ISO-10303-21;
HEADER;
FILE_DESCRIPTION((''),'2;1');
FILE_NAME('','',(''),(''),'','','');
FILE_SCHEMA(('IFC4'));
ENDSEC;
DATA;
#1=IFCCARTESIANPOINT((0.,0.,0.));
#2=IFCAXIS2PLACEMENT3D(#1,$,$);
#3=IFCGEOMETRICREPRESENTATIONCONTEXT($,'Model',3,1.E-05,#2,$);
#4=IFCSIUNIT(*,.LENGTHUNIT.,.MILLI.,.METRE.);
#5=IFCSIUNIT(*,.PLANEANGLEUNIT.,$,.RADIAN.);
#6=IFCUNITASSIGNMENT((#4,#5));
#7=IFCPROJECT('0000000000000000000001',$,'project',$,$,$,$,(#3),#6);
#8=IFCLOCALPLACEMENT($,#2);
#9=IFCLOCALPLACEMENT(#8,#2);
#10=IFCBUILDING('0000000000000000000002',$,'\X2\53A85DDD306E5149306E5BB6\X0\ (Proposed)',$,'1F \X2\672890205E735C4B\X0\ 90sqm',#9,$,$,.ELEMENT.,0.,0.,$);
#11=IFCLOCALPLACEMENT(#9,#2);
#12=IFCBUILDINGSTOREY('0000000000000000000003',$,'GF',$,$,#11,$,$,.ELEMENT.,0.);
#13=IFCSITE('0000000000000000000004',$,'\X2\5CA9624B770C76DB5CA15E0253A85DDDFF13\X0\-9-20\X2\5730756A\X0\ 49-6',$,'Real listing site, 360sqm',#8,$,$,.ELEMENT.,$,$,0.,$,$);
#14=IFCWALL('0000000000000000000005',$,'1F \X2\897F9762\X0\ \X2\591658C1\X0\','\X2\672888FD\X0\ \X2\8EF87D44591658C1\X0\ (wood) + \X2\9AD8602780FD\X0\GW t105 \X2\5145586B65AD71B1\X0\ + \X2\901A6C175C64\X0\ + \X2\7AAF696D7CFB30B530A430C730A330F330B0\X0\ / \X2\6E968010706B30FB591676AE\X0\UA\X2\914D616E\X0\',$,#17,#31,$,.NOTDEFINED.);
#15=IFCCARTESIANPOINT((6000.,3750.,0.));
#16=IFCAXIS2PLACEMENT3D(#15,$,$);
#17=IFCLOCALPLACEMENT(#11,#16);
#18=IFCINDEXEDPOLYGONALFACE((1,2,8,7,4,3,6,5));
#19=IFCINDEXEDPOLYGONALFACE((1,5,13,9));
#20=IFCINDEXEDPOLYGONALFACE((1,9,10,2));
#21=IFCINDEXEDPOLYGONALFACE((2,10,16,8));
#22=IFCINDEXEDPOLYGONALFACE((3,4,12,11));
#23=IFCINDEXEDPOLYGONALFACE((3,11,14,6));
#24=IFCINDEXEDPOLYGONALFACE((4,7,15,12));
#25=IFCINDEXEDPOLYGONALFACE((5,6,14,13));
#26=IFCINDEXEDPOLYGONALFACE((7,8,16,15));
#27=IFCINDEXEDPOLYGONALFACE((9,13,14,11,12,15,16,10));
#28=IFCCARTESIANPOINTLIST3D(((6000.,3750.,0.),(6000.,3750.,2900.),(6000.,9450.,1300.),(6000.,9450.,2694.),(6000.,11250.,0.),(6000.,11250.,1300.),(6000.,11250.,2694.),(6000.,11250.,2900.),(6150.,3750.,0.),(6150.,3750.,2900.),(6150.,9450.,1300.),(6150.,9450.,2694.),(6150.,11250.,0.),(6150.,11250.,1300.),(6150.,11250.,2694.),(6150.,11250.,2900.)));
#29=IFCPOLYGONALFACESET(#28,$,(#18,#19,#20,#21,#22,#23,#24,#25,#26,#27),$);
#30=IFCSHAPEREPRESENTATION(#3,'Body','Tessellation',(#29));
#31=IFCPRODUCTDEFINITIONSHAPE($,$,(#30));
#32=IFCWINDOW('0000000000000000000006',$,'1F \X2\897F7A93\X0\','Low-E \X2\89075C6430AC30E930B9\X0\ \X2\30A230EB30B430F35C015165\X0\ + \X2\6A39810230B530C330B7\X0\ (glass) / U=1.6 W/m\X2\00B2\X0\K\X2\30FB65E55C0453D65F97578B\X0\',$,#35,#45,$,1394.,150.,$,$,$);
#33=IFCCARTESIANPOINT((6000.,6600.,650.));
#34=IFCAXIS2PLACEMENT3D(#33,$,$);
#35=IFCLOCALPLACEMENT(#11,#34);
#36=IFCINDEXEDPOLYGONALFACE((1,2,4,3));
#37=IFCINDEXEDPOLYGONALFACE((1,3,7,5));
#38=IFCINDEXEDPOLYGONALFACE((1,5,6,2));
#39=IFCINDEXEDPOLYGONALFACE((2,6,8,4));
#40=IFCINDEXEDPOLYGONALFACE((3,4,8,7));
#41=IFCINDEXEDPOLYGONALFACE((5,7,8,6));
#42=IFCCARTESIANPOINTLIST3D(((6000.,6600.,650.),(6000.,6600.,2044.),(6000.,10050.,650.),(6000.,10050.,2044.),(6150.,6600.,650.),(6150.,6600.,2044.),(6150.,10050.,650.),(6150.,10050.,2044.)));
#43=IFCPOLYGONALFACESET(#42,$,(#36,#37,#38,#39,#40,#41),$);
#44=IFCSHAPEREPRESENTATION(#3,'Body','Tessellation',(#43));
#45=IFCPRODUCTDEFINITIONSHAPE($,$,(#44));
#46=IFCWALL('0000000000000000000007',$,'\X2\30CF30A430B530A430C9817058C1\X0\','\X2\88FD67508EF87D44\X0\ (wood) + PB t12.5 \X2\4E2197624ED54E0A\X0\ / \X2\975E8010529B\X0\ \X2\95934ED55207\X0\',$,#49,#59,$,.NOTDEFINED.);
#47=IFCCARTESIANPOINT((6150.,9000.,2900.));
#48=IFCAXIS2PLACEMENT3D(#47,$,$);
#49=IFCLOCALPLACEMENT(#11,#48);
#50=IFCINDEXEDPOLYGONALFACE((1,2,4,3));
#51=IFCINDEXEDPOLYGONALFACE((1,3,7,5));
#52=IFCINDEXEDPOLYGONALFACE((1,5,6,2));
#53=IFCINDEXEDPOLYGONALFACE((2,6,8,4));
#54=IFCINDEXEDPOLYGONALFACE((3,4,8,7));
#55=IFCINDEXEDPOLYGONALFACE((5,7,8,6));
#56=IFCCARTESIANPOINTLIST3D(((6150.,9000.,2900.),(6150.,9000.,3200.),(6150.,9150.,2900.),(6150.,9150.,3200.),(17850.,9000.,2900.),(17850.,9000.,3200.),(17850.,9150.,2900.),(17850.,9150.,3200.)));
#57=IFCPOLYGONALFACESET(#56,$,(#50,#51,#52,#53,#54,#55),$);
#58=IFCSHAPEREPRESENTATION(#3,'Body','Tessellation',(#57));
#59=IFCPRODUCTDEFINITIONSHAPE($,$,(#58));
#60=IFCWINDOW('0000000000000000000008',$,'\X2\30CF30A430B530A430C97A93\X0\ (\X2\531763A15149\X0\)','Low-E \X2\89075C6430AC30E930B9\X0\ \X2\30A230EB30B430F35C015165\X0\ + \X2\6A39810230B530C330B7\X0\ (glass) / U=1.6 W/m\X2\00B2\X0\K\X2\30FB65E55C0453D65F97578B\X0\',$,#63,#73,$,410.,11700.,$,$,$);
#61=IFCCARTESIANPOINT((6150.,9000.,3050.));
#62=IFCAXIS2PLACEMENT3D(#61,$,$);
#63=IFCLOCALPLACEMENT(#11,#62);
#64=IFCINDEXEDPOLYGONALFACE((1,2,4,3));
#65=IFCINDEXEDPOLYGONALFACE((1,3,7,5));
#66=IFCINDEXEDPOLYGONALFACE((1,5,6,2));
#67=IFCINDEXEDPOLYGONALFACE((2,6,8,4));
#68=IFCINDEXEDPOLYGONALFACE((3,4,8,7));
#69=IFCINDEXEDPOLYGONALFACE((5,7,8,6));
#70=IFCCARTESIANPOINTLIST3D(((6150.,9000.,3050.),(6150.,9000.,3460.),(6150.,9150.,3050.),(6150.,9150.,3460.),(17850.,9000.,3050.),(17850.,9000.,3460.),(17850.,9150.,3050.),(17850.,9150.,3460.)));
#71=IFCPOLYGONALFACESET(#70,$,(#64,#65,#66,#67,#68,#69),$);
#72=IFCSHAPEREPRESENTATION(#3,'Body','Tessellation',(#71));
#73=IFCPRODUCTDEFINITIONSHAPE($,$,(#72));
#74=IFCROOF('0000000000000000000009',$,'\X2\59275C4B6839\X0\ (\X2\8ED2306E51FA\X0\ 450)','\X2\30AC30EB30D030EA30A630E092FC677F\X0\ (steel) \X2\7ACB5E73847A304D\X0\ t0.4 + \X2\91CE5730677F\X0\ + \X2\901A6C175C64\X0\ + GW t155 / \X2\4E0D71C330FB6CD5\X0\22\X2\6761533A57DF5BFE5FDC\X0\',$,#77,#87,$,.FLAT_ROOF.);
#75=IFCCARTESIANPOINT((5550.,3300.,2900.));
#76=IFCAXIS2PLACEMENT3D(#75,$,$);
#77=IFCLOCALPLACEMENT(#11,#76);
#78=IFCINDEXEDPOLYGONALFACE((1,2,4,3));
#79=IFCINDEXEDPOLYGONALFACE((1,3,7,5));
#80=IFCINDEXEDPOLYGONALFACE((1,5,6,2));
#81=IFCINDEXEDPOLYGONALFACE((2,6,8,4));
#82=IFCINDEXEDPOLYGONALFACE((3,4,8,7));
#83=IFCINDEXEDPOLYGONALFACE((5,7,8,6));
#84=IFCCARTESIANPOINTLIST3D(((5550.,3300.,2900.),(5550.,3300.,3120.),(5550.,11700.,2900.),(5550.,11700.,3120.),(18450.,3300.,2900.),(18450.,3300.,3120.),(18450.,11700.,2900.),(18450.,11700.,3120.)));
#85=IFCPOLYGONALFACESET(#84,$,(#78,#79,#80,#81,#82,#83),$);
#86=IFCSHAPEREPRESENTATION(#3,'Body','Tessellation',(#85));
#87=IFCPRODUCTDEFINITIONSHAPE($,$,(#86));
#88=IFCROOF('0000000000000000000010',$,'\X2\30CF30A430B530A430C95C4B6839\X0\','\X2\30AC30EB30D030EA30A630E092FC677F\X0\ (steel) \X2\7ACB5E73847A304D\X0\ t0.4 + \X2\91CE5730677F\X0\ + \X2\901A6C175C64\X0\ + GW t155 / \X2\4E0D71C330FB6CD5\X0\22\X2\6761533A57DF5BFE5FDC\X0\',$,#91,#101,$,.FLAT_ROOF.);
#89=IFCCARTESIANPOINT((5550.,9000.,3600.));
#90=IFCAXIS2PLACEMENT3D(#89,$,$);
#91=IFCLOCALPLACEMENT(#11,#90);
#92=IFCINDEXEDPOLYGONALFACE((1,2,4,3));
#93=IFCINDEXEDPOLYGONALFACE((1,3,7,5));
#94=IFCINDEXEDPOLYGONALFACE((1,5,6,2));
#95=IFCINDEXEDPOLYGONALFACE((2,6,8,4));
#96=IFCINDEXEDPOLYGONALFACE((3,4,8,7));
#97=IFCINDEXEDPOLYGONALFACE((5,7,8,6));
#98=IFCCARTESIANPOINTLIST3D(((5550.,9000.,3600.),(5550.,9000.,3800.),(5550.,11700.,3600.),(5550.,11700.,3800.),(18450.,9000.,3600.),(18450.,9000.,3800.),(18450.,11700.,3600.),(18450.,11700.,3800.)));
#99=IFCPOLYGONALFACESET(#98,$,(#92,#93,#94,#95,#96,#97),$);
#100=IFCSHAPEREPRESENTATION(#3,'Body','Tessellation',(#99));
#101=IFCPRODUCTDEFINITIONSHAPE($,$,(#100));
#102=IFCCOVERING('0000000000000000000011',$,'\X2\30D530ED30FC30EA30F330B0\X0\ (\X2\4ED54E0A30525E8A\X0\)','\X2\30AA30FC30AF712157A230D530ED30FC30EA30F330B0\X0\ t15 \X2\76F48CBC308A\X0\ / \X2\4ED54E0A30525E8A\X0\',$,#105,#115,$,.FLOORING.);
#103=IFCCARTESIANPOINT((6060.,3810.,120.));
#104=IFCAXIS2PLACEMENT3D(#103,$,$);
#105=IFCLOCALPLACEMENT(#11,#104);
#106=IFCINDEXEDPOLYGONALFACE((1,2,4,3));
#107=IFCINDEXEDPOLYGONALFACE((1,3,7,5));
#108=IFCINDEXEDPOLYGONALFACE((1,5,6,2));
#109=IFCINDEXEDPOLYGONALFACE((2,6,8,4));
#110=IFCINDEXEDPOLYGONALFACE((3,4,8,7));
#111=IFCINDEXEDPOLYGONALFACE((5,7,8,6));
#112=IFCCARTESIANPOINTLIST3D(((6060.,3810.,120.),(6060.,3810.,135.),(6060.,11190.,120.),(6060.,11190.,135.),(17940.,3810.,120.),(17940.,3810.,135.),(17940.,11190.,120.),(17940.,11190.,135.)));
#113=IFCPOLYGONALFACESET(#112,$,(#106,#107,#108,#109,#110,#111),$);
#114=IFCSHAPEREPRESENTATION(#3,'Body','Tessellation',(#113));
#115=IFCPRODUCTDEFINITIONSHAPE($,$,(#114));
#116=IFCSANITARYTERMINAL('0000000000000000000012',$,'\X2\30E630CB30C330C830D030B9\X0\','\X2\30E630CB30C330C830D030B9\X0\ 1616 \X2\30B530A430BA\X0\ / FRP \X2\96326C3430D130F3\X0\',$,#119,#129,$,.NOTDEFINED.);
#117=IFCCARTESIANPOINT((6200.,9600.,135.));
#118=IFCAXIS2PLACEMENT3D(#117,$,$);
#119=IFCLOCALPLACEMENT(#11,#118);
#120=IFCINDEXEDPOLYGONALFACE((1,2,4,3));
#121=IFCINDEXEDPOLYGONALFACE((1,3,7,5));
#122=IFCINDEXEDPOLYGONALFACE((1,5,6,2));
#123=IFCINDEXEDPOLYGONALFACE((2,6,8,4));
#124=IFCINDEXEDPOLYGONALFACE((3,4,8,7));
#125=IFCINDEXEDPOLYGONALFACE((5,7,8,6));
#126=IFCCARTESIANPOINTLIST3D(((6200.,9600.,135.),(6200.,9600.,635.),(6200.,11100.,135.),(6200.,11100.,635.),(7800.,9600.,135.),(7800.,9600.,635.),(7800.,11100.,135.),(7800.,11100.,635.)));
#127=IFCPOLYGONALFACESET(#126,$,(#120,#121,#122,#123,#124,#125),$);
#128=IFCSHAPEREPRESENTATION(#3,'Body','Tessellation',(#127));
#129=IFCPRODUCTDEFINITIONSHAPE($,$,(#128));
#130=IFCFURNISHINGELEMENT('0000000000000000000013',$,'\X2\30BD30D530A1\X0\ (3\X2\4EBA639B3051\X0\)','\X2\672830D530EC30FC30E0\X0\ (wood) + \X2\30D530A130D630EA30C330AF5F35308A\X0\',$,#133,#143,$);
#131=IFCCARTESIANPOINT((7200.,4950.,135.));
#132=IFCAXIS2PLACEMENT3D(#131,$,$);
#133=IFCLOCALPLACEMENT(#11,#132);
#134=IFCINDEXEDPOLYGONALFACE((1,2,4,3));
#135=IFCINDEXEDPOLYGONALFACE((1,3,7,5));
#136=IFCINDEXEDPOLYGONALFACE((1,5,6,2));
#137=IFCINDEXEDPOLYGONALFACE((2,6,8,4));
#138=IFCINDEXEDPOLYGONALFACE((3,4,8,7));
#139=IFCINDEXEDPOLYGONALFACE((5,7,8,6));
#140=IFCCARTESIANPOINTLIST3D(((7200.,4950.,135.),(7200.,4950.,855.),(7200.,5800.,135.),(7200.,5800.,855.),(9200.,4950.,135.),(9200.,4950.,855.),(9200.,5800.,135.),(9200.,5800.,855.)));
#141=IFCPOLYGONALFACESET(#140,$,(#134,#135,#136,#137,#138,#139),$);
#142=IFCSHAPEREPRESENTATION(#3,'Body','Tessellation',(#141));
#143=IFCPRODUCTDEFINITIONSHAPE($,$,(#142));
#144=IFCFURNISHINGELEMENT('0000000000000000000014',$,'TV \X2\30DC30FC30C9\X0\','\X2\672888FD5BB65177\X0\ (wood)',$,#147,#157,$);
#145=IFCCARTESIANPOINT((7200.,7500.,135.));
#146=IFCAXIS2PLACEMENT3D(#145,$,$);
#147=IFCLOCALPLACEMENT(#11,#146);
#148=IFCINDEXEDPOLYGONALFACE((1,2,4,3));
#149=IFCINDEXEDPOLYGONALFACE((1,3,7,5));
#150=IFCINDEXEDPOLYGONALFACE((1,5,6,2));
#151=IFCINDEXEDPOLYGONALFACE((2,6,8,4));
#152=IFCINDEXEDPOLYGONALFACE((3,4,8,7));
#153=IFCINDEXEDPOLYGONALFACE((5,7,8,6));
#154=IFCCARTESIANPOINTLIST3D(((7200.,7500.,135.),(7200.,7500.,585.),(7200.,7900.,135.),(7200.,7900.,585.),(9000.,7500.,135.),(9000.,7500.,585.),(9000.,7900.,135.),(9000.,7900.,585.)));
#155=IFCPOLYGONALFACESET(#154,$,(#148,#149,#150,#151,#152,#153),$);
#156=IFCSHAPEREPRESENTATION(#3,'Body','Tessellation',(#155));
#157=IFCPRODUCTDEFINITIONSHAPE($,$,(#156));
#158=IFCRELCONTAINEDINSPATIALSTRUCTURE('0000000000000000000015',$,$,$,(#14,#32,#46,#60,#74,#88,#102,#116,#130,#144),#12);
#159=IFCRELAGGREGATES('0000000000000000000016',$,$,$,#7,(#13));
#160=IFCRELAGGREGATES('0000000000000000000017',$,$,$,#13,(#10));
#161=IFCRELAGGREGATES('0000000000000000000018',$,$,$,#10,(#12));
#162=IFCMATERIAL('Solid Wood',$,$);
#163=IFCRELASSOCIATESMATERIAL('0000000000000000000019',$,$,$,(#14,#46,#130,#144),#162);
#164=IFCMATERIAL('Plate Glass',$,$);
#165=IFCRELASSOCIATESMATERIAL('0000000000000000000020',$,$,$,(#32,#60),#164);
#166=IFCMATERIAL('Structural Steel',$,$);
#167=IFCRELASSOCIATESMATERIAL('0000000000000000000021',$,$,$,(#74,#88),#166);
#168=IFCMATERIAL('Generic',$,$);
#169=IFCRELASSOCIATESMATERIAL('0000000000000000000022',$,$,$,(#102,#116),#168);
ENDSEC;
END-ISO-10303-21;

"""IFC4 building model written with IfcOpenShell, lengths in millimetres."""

from ifc_helpers import new_model, si_unit, frame, frame_2d, origin, place, context, project, spatial, rectangle, extrude, material, element, fill, save


model = new_model("IFC4")

# Units and contexts
model_context = context("Model", 3, precision=1e-05, world=origin())
ifc_project = project(units=[si_unit("LENGTHUNIT", "METRE", prefix="MILLI"), si_unit("PLANEANGLEUNIT", "RADIAN")], contexts=[model_context])

# Site, building, storey
site_placement = place(None, origin())
site = spatial("IfcSite", under=ifc_project, at=site_placement, Name="岩手県盛岡市厨川３-9-20地番 49-6", ObjectType="Real listing site, 360sqm", CompositionType="ELEMENT", RefElevation=0.0)
building_placement = place(site_placement, origin())
building = spatial("IfcBuilding", under=site, at=building_placement, Name="厨川の光の家 (Proposed)", ObjectType="1F 木造平屋 90sqm", CompositionType="ELEMENT", ElevationOfRefHeight=0.0, ElevationOfTerrain=0.0)
storey_placement = place(building_placement, origin())
storey = spatial("IfcBuildingStorey", under=building, at=storey_placement, Name="GF", CompositionType="ELEMENT", Elevation=0.0)

# Shared definitions
ifc_material_1 = material(Name="Solid Wood")

# Shared definitions
ifc_material_2 = material(Name="Plate Glass")

# Wall, opening, window
wall_1_placement = place(storey_placement, frame((6000.0, 3750.0, 0.0)))
wall_1 = element("IfcWall", 1, at=wall_1_placement, inside=storey, material=ifc_material_1, Name="1F 西面 外壁", Description="木製 軸組外壁 (wood) + 高性能GW t105 充填断熱 + 通気層 + 窯業系サイディング / 準耐火・外皮UA配慮", PredefinedType="NOTDEFINED", context=model_context, shape_type="SweptSolid", body=[
    extrude(rectangle(XDim=150.0, YDim=7500.0, at=frame_2d((75.0, 3750.0))), frame((6000.0, 3750.0, 0.0)), (0.0, 0.0, 1.0), 2900.0),
])
opening_1_placement = place(storey_placement, frame((6000.0, 6600.0, 650.0)))
opening_1 = element("IfcOpeningElement", 2, at=opening_1_placement, cuts=wall_1, PredefinedType="NOTDEFINED", context=model_context, shape_type="SweptSolid", body=[
    extrude(rectangle(XDim=150.0, YDim=3450.0, at=frame_2d((75.0, 1725.0))), frame((6000.0, 6600.0, 650.0)), (0.0, 0.0, 1.0), 1394.0),
])
window_1_placement = place(storey_placement, frame((6000.0, 6600.0, 650.0)))
window_1 = element("IfcWindow", 3, at=window_1_placement, inside=storey, material=ifc_material_2, Name="1F 西窓", Description="Low-E 複層ガラス アルゴン封入 + 樹脂サッシ (glass) / U=1.6 W/m²K・日射取得型", OverallHeight=1394.0, OverallWidth=150.0, context=model_context, shape_type="SweptSolid", body=[
    extrude(rectangle(XDim=150.0, YDim=3450.0, at=frame_2d((75.0, 1725.0))), frame((6000.0, 6600.0, 650.0)), (0.0, 0.0, 1.0), 1394.0),
])
fill(opening_1, window_1)

# Wall, opening, window
wall_2_placement = place(storey_placement, frame((6150.0, 9000.0, 2900.0)))
wall_2 = element("IfcWall", 4, at=wall_2_placement, inside=storey, material=ifc_material_1, Name="ハイサイド腰壁", Description="製材軸組 (wood) + PB t12.5 両面仕上 / 非耐力 間仕切", PredefinedType="NOTDEFINED", context=model_context, shape_type="SweptSolid", body=[
    extrude(rectangle(XDim=11700.0, YDim=150.0, at=frame_2d((5850.0, 75.0))), frame((6150.0, 9000.0, 2900.0)), (0.0, 0.0, 1.0), 700.0),
])
opening_2_placement = place(storey_placement, frame((6150.0, 9000.0, 3050.0)))
opening_2 = element("IfcOpeningElement", 5, at=opening_2_placement, cuts=wall_2, PredefinedType="NOTDEFINED", context=model_context, shape_type="SweptSolid", body=[
    extrude(rectangle(XDim=11700.0, YDim=150.0, at=frame_2d((5850.0, 75.0))), frame((6150.0, 9000.0, 3050.0)), (0.0, 0.0, 1.0), 410.0),
])
window_2_placement = place(storey_placement, frame((6150.0, 9000.0, 3050.0)))
window_2 = element("IfcWindow", 6, at=window_2_placement, inside=storey, material=ifc_material_2, Name="ハイサイド窓 (北採光)", Description="Low-E 複層ガラス アルゴン封入 + 樹脂サッシ (glass) / U=1.6 W/m²K・日射取得型", OverallHeight=410.0, OverallWidth=11700.0, context=model_context, shape_type="SweptSolid", body=[
    extrude(rectangle(XDim=11700.0, YDim=150.0, at=frame_2d((5850.0, 75.0))), frame((6150.0, 9000.0, 3050.0)), (0.0, 0.0, 1.0), 410.0),
])
fill(opening_2, window_2)

# Roofs
ifc_material_3 = material(Name="Structural Steel")
roof_1_placement = place(storey_placement, frame((5550.0, 3300.0, 2900.0)))
element("IfcRoof", 7, at=roof_1_placement, inside=storey, material=ifc_material_3, Name="大屋根 (軒の出 450)", Description="ガルバリウム鋼板 (steel) 立平葺き t0.4 + 野地板 + 通気層 + GW t155 / 不燃・法22条区域対応", PredefinedType="FLAT_ROOF", context=model_context, shape_type="SweptSolid", body=[
    extrude(rectangle(XDim=12900.0, YDim=8400.0, at=frame_2d((6450.0, 4200.0))), frame((5550.0, 3300.0, 2900.0)), (0.0, 0.0, 1.0), 220.0),
])
roof_2_placement = place(storey_placement, frame((5550.0, 9000.0, 3600.0)))
element("IfcRoof", 8, at=roof_2_placement, inside=storey, material=ifc_material_3, Name="ハイサイド屋根", Description="ガルバリウム鋼板 (steel) 立平葺き t0.4 + 野地板 + 通気層 + GW t155 / 不燃・法22条区域対応", PredefinedType="FLAT_ROOF", context=model_context, shape_type="SweptSolid", body=[
    extrude(rectangle(XDim=12900.0, YDim=2700.0, at=frame_2d((6450.0, 1350.0))), frame((5550.0, 9000.0, 3600.0)), (0.0, 0.0, 1.0), 200.0),
])

# Covering
ifc_material_4 = material(Name="Generic")
covering_placement = place(storey_placement, frame((6060.0, 3810.0, 120.0)))
element("IfcCovering", 9, at=covering_placement, inside=storey, material=ifc_material_4, Name="フローリング (仕上げ床)", Description="オーク無垢フローリング t15 直貼り / 仕上げ床", PredefinedType="FLOORING", context=model_context, shape_type="SweptSolid", body=[
    extrude(rectangle(XDim=11880.0, YDim=7380.0, at=frame_2d((5940.0, 3690.0))), frame((6060.0, 3810.0, 120.0)), (0.0, 0.0, 1.0), 15.0),
])

# Sanitary terminal
sanitary_terminal_placement = place(storey_placement, frame((6200.0, 9600.0, 135.0)))
element("IfcSanitaryTerminal", 10, at=sanitary_terminal_placement, inside=storey, material=ifc_material_4, Name="ユニットバス", Description="ユニットバス 1616 サイズ / FRP 防水パン", PredefinedType="NOTDEFINED", context=model_context, shape_type="SweptSolid", body=[
    extrude(rectangle(XDim=1600.0, YDim=1500.0, at=frame_2d((800.0, 750.0))), frame((6200.0, 9600.0, 135.0)), (0.0, 0.0, 1.0), 500.0),
])

# Furnishing elements
furnishing_1_placement = place(storey_placement, frame((7200.0, 4950.0, 135.0)))
element("IfcFurnishingElement", 11, at=furnishing_1_placement, inside=storey, material=ifc_material_1, Name="ソファ (3人掛け)", Description="木フレーム (wood) + ファブリック張り", context=model_context, shape_type="SweptSolid", body=[
    extrude(rectangle(XDim=2000.0, YDim=850.0, at=frame_2d((1000.0, 425.0))), frame((7200.0, 4950.0, 135.0)), (0.0, 0.0, 1.0), 720.0),
])
furnishing_2_placement = place(storey_placement, frame((7200.0, 7500.0, 135.0)))
element("IfcFurnishingElement", 12, at=furnishing_2_placement, inside=storey, material=ifc_material_1, Name="TV ボード", Description="木製家具 (wood)", context=model_context, shape_type="SweptSolid", body=[
    extrude(rectangle(XDim=1800.0, YDim=400.0, at=frame_2d((900.0, 200.0))), frame((7200.0, 7500.0, 135.0)), (0.0, 0.0, 1.0), 450.0),
])

save(model, "model.ifc")
